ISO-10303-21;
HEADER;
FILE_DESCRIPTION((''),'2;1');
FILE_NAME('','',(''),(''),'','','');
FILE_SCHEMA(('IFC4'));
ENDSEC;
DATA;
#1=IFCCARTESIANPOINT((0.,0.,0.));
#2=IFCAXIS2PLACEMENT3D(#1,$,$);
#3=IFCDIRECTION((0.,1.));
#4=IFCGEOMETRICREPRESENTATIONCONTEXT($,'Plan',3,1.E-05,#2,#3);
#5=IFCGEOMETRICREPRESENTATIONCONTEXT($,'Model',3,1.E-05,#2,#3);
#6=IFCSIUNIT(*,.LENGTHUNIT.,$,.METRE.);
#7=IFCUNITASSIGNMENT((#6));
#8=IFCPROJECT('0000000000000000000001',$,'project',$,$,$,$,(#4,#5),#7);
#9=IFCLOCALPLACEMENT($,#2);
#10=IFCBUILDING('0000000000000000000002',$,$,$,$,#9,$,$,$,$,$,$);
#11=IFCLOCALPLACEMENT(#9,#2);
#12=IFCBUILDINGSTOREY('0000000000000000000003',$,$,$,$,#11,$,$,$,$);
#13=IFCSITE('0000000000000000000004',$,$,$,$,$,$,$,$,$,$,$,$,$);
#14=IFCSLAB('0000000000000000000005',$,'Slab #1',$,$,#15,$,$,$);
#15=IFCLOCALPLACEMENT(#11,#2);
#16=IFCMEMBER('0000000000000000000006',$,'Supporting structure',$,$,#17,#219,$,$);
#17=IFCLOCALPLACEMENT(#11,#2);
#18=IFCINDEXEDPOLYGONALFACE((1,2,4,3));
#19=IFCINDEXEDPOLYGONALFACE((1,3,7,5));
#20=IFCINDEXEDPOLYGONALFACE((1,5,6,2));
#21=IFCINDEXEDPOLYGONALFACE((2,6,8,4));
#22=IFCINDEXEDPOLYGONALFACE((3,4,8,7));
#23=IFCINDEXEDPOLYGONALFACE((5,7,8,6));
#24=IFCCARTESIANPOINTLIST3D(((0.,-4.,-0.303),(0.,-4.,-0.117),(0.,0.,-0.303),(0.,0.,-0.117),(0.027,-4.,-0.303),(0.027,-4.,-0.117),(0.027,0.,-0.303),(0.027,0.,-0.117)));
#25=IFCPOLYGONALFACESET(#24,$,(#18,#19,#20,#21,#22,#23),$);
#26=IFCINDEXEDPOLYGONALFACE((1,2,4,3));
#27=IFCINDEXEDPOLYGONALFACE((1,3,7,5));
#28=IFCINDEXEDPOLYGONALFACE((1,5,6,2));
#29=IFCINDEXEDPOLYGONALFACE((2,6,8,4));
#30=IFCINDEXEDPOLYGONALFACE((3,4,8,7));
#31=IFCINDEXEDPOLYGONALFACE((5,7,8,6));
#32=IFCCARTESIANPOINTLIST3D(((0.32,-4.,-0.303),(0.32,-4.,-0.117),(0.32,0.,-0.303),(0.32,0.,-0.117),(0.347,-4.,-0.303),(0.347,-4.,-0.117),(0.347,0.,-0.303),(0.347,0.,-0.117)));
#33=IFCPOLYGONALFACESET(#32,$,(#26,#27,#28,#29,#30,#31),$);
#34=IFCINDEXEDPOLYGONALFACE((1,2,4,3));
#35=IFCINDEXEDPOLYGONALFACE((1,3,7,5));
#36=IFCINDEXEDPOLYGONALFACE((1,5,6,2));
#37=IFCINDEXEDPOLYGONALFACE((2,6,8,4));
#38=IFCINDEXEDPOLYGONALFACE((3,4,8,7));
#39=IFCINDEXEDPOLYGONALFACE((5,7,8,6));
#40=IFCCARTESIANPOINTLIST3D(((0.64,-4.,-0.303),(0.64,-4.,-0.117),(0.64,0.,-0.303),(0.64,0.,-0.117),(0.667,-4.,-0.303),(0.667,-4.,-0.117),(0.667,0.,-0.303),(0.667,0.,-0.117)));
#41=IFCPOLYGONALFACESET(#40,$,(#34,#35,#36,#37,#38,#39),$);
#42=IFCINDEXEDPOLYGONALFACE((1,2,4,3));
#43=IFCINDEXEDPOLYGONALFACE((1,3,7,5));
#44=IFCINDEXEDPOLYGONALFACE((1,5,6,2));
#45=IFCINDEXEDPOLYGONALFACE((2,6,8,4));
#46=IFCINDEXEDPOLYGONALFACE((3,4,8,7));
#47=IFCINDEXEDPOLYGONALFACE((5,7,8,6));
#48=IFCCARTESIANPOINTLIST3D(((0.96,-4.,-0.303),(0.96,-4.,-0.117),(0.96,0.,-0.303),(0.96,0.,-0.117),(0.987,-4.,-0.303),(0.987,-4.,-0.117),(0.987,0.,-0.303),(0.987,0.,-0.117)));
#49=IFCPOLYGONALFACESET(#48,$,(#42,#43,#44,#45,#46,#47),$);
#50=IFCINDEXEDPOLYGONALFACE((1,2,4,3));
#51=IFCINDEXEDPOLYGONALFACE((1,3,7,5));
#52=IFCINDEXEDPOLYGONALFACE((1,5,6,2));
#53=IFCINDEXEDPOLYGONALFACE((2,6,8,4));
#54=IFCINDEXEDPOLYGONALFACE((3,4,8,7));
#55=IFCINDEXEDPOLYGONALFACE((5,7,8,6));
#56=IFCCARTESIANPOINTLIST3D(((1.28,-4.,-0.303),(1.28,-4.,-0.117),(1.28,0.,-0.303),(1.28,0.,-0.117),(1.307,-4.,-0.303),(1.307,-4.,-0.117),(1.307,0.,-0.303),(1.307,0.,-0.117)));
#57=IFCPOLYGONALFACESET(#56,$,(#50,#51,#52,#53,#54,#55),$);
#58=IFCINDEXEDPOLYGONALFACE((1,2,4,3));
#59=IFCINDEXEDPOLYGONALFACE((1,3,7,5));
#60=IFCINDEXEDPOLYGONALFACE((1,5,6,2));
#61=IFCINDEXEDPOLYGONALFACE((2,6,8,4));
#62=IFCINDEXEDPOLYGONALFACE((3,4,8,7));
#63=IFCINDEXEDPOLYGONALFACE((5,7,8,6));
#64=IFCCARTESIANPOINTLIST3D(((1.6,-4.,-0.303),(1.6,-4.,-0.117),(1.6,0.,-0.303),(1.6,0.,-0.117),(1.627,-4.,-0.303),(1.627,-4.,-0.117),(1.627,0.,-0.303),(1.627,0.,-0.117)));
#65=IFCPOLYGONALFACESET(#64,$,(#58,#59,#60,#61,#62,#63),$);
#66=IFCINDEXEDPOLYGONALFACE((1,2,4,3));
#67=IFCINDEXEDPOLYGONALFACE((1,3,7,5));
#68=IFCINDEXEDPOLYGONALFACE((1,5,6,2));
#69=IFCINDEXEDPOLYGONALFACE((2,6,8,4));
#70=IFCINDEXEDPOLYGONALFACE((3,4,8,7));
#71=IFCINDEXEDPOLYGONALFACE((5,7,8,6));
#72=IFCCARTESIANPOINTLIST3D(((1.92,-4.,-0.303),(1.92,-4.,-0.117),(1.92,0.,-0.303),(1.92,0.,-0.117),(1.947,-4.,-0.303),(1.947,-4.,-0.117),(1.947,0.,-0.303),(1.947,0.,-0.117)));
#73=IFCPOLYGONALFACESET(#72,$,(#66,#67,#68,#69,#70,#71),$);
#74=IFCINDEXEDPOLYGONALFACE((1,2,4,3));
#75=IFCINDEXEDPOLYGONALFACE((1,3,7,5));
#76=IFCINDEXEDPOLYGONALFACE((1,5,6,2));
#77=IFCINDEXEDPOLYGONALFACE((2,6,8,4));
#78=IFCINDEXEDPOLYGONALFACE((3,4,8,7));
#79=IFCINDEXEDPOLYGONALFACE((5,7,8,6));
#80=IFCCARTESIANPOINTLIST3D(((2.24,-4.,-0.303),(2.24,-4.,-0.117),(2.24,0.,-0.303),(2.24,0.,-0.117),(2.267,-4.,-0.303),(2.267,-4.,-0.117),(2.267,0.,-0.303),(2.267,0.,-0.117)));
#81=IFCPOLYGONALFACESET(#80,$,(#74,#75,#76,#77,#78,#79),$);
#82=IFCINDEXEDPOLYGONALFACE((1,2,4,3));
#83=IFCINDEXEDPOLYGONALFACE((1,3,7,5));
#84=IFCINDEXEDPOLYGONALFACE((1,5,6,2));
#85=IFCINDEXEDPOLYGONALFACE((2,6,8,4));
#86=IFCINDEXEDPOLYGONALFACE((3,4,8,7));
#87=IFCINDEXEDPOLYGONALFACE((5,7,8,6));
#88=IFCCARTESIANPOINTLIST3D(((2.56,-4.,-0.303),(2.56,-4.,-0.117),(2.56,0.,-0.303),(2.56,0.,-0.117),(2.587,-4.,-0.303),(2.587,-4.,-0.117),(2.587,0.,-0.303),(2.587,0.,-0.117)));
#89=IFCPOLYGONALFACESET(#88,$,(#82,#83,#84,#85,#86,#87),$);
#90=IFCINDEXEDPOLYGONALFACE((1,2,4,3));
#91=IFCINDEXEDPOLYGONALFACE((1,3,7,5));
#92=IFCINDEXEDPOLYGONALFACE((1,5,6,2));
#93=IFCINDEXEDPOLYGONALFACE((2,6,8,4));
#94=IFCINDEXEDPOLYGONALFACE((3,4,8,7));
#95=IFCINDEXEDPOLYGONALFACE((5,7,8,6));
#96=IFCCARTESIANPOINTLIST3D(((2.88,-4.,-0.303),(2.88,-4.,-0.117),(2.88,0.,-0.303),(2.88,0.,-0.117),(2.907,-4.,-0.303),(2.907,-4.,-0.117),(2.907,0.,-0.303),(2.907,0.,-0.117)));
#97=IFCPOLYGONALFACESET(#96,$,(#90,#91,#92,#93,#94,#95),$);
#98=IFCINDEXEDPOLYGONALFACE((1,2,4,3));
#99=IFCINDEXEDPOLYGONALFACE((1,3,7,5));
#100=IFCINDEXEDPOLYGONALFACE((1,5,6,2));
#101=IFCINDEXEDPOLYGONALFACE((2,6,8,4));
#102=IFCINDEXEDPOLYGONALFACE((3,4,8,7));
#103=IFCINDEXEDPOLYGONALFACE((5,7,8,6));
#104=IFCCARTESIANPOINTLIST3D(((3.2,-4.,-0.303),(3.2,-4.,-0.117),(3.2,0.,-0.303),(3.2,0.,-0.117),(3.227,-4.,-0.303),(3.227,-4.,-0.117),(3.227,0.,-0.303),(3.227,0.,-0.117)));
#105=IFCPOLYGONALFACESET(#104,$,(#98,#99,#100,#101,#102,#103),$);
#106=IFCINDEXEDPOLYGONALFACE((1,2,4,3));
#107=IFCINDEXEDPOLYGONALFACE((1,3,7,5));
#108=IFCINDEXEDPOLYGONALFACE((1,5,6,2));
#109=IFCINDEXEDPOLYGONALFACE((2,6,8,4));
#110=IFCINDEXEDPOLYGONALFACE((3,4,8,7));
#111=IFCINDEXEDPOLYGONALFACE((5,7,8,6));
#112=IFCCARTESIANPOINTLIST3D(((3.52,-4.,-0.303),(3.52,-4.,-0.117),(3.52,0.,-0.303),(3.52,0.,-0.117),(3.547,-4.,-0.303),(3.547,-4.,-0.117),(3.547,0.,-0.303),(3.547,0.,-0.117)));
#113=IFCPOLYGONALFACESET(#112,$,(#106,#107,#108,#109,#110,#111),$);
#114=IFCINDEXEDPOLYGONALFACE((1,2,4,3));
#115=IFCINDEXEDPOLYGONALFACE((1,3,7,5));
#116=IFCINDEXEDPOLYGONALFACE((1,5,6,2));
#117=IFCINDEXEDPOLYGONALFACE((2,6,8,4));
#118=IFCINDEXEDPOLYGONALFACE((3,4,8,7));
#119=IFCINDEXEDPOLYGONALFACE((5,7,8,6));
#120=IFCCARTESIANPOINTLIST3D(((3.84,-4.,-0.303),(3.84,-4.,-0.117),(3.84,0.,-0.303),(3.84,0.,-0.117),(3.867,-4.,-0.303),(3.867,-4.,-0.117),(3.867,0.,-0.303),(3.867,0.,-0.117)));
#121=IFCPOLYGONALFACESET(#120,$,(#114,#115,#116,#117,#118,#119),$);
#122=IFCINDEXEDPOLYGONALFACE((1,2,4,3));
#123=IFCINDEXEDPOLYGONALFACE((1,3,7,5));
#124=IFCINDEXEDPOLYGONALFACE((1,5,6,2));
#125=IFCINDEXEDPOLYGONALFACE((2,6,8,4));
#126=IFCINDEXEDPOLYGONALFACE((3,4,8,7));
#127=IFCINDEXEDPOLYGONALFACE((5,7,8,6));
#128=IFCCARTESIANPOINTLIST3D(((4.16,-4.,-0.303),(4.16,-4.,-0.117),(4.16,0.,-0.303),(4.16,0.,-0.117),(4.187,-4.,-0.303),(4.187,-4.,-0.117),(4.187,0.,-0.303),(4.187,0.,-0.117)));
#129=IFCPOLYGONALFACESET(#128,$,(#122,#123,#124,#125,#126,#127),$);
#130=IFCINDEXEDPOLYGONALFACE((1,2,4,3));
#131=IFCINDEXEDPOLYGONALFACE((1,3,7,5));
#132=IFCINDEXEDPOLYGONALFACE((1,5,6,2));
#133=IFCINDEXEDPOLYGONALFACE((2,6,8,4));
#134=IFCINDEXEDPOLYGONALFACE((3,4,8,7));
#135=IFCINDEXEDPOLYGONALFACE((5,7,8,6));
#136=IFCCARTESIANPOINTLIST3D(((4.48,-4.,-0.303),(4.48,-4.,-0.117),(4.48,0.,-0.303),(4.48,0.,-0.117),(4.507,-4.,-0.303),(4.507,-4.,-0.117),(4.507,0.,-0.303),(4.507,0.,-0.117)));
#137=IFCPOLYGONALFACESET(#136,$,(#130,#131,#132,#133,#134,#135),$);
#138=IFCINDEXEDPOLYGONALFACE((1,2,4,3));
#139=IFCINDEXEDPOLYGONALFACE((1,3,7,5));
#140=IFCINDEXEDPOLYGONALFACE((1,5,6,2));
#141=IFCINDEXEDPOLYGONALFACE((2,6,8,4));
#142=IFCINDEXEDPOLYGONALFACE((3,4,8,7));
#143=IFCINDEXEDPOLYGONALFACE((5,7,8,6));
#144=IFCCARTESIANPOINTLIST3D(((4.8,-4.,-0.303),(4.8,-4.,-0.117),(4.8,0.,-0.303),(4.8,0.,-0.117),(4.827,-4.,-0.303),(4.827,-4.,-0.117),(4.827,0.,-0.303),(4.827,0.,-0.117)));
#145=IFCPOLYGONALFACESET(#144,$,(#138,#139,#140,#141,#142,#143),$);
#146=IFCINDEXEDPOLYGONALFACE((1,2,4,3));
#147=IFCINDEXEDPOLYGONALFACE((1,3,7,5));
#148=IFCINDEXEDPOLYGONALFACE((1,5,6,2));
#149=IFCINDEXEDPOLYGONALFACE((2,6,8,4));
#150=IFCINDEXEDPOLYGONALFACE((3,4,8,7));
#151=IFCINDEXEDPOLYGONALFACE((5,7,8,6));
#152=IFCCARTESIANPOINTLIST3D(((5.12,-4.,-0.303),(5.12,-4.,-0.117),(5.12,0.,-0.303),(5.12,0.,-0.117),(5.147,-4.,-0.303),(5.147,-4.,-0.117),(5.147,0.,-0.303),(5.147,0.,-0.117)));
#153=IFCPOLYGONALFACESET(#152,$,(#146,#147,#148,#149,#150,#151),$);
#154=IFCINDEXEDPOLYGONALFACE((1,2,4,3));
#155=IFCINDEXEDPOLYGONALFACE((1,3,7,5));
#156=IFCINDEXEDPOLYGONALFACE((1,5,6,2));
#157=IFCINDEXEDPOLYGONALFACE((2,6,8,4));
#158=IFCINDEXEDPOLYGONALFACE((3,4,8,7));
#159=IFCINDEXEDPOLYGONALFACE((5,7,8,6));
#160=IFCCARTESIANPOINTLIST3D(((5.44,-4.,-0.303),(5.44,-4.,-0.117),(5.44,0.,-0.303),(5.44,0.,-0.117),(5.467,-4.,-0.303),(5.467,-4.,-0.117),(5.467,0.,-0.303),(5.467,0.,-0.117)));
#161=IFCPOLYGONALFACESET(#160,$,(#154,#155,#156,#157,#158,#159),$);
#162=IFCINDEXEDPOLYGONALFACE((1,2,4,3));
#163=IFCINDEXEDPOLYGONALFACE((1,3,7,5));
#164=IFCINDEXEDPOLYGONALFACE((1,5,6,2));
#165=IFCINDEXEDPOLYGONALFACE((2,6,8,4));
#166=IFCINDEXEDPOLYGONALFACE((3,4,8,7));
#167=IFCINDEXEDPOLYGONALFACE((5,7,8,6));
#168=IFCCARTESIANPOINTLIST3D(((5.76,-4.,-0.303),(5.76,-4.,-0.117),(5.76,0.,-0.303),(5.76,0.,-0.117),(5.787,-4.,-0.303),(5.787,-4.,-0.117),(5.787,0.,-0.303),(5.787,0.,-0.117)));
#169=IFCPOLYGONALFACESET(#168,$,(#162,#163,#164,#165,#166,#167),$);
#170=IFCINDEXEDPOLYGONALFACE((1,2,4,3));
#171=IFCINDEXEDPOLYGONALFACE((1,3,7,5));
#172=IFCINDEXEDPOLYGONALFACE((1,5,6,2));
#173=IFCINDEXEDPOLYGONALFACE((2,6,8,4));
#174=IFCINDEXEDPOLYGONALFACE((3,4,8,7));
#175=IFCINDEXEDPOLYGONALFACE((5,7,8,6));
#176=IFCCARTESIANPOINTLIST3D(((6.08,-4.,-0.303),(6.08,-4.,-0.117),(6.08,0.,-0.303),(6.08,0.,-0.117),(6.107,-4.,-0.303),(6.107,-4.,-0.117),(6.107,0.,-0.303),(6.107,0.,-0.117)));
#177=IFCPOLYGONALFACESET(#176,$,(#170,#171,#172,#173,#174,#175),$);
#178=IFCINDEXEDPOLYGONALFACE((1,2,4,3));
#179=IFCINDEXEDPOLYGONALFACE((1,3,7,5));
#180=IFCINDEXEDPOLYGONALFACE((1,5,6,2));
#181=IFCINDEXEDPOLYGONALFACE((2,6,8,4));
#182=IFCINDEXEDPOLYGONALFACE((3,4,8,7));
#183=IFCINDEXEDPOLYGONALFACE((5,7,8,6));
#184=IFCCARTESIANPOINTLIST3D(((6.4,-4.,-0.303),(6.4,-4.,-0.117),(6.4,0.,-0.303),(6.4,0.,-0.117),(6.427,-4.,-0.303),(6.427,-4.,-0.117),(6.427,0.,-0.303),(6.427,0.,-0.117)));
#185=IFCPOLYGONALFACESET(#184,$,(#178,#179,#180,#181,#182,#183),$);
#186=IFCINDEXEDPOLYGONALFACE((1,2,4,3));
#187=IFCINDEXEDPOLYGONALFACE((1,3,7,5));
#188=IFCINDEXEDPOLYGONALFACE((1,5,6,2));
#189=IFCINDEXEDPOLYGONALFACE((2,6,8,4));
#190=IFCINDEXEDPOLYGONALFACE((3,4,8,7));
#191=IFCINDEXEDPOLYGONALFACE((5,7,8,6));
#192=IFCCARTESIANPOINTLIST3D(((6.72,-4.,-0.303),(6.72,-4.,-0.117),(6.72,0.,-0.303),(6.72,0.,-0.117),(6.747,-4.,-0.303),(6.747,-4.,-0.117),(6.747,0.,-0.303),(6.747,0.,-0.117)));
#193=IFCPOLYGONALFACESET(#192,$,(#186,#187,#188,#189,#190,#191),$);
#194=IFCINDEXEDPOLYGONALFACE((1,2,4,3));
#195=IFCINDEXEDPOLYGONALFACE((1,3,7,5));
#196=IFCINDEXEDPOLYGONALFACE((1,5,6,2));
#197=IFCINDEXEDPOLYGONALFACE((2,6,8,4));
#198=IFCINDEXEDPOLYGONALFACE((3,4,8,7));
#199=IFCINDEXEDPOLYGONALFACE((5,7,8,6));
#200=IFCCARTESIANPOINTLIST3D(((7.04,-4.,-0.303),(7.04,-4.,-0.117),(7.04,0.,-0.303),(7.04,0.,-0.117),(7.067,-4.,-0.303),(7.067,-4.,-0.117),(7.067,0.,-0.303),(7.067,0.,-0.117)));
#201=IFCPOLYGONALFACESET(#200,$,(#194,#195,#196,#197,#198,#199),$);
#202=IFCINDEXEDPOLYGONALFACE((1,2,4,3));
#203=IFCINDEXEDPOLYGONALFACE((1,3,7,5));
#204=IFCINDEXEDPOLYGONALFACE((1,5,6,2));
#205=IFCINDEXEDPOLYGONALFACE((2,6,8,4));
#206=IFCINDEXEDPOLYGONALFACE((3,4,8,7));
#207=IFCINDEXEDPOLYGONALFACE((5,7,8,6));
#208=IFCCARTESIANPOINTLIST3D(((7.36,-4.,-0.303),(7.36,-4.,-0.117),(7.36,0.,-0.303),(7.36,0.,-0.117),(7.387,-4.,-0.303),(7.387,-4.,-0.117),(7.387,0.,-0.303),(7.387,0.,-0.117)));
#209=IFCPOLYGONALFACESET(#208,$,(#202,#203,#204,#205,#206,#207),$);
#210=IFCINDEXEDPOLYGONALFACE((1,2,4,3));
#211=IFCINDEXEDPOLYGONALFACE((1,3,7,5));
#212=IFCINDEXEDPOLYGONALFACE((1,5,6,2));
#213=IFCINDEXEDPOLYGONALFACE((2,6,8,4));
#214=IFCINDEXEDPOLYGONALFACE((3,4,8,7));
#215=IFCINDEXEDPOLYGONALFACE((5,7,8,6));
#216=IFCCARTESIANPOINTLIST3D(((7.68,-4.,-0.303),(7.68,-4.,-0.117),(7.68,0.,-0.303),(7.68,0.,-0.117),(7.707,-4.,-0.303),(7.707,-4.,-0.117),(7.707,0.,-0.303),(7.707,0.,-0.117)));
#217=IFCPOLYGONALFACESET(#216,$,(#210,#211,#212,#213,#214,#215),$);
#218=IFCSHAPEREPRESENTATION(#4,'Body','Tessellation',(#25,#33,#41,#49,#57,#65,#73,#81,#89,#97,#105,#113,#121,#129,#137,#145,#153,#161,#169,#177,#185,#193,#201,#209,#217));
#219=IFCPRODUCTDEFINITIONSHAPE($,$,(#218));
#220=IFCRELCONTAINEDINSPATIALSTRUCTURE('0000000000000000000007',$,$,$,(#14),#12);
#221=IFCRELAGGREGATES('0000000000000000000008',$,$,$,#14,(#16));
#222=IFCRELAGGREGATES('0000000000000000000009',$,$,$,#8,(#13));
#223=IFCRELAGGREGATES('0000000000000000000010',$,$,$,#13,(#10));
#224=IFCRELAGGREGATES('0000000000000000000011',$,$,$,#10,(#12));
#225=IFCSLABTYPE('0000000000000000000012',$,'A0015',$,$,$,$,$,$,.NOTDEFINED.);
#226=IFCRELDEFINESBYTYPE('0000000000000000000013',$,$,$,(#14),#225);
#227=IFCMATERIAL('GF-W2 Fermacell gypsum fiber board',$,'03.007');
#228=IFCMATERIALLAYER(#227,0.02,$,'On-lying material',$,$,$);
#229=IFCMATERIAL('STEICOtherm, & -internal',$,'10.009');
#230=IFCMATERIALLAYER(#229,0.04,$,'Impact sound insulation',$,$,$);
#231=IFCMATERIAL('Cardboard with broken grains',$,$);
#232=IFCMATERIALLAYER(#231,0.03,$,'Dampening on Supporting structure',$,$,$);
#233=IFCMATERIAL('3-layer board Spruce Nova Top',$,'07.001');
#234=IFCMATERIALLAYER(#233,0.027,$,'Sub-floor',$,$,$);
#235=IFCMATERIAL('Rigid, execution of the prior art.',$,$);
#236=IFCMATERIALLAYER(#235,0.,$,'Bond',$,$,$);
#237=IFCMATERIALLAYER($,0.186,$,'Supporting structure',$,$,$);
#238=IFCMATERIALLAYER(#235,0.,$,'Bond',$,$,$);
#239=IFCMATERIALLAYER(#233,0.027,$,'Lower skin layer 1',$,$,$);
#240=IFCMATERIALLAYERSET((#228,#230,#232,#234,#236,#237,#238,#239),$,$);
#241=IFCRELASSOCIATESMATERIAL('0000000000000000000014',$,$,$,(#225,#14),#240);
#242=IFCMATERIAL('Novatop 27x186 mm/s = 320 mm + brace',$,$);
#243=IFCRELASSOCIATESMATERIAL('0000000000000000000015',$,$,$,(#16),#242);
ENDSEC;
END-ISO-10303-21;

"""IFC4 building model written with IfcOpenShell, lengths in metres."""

from ifc_helpers import new_model, si_unit, direction, frame, frame_2d, origin, place, context, project, spatial, rectangle, extrude, material, layer, layer_set, type_object, element, aggregate, save


model = new_model("IFC4")

# Units and contexts
plan_context = context("Plan", 3, precision=1e-05, world=origin(), true_north=direction((0.0, 1.0)))
model_context = context("Model", 3, precision=1e-05, world=origin(), true_north=direction((0.0, 1.0)))
ifc_project = project(units=[si_unit("LENGTHUNIT", "METRE")], contexts=[plan_context, model_context])

# Site, building, storey
site = spatial("IfcSite", under=ifc_project)
building_placement = place(None, origin())
building = spatial("IfcBuilding", under=site, at=building_placement)
storey_placement = place(building_placement, origin())
storey = spatial("IfcBuildingStorey", under=building, at=storey_placement)

# Slab, member
ifc_material_1 = material(Name="GF-W2 Fermacell gypsum fiber board", Category="03.007")
ifc_layer_1 = layer(ifc_material_1, 0.02, Name="On-lying material")
ifc_material_2 = material(Name="STEICOtherm, & -internal", Category="10.009")
ifc_layer_2 = layer(ifc_material_2, 0.04, Name="Impact sound insulation")
ifc_material_3 = material(Name="Cardboard with broken grains")
ifc_layer_3 = layer(ifc_material_3, 0.03, Name="Dampening on Supporting structure")
ifc_material_4 = material(Name="3-layer board Spruce Nova Top", Category="07.001")
ifc_layer_4 = layer(ifc_material_4, 0.027, Name="Sub-floor")
ifc_material_5 = material(Name="Rigid, execution of the prior art.")
ifc_layer_5 = layer(ifc_material_5, 0.0, Name="Bond")
ifc_layer_6 = layer(None, 0.186, Name="Supporting structure")
ifc_layer_7 = layer(ifc_material_5, 0.0, Name="Bond")
ifc_layer_8 = layer(ifc_material_4, 0.027, Name="Lower skin layer 1")
ifc_layer_set = layer_set([ifc_layer_1, ifc_layer_2, ifc_layer_3, ifc_layer_4, ifc_layer_5, ifc_layer_6, ifc_layer_7, ifc_layer_8])
slab_type = type_object("IfcSlabType", Name="A0015", PredefinedType="NOTDEFINED", material=ifc_layer_set)
slab_placement = place(None, frame((0.0, 0.0, 0.0), z_axis=(0.0, 0.0, -1.0), x_axis=(1.0, 0.0, 0.0)))
slab = element("IfcSlab", 1, at=slab_placement, inside=storey, type_object=slab_type, material=ifc_layer_set, Name="Slab #1")
ifc_material_6 = material(Name="Novatop 27x186 mm/s = 320 mm + brace")
member_1_placement = place(slab_placement, origin())
member_1 = element("IfcMember", 2, at=member_1_placement, material=ifc_material_6, Name="Supporting structure", context=plan_context, shape_type="SweptSolid", body=[
    extrude(rectangle(XDim=0.027, YDim=0.186, at=frame_2d((0.0135, 0.093), x_axis=(1.0, 0.0))), frame((0.0, 4.0, 0.117), z_axis=(0.0, -1.0, 0.0), x_axis=(1.0, 0.0, 0.0)), (0.0, 0.0, 1.0), 4.0),
    extrude(rectangle(XDim=0.027, YDim=0.186, at=frame_2d((0.0135, 0.093), x_axis=(1.0, 0.0))), frame((0.32, 4.0, 0.117), z_axis=(0.0, -1.0, 0.0), x_axis=(1.0, 0.0, 0.0)), (0.0, 0.0, 1.0), 4.0),
    extrude(rectangle(XDim=0.027, YDim=0.186, at=frame_2d((0.0135, 0.093), x_axis=(1.0, 0.0))), frame((0.64, 4.0, 0.117), z_axis=(0.0, -1.0, 0.0), x_axis=(1.0, 0.0, 0.0)), (0.0, 0.0, 1.0), 4.0),
    extrude(rectangle(XDim=0.027, YDim=0.186, at=frame_2d((0.0135, 0.093), x_axis=(1.0, 0.0))), frame((0.96, 4.0, 0.117), z_axis=(0.0, -1.0, 0.0), x_axis=(1.0, 0.0, 0.0)), (0.0, 0.0, 1.0), 4.0),
    extrude(rectangle(XDim=0.027, YDim=0.186, at=frame_2d((0.0135, 0.093), x_axis=(1.0, 0.0))), frame((1.28, 4.0, 0.117), z_axis=(0.0, -1.0, 0.0), x_axis=(1.0, 0.0, 0.0)), (0.0, 0.0, 1.0), 4.0),
    extrude(rectangle(XDim=0.027, YDim=0.186, at=frame_2d((0.0135, 0.093), x_axis=(1.0, 0.0))), frame((1.6, 4.0, 0.117), z_axis=(0.0, -1.0, 0.0), x_axis=(1.0, 0.0, 0.0)), (0.0, 0.0, 1.0), 4.0),
    extrude(rectangle(XDim=0.027, YDim=0.186, at=frame_2d((0.0135, 0.093), x_axis=(1.0, 0.0))), frame((1.92, 4.0, 0.117), z_axis=(0.0, -1.0, 0.0), x_axis=(1.0, 0.0, 0.0)), (0.0, 0.0, 1.0), 4.0),
    extrude(rectangle(XDim=0.027, YDim=0.186, at=frame_2d((0.0135, 0.093), x_axis=(1.0, 0.0))), frame((2.24, 4.0, 0.117), z_axis=(0.0, -1.0, 0.0), x_axis=(1.0, 0.0, 0.0)), (0.0, 0.0, 1.0), 4.0),
    extrude(rectangle(XDim=0.027, YDim=0.186, at=frame_2d((0.0135, 0.093), x_axis=(1.0, 0.0))), frame((2.56, 4.0, 0.117), z_axis=(0.0, -1.0, 0.0), x_axis=(1.0, 0.0, 0.0)), (0.0, 0.0, 1.0), 4.0),
    extrude(rectangle(XDim=0.027, YDim=0.186, at=frame_2d((0.0135, 0.093), x_axis=(1.0, 0.0))), frame((2.88, 4.0, 0.117), z_axis=(0.0, -1.0, 0.0), x_axis=(1.0, 0.0, 0.0)), (0.0, 0.0, 1.0), 4.0),
    extrude(rectangle(XDim=0.027, YDim=0.186, at=frame_2d((0.0135, 0.093), x_axis=(1.0, 0.0))), frame((3.2, 4.0, 0.117), z_axis=(0.0, -1.0, 0.0), x_axis=(1.0, 0.0, 0.0)), (0.0, 0.0, 1.0), 4.0),
    extrude(rectangle(XDim=0.027, YDim=0.186, at=frame_2d((0.0135, 0.093), x_axis=(1.0, 0.0))), frame((3.52, 4.0, 0.117), z_axis=(0.0, -1.0, 0.0), x_axis=(1.0, 0.0, 0.0)), (0.0, 0.0, 1.0), 4.0),
    extrude(rectangle(XDim=0.027, YDim=0.186, at=frame_2d((0.0135, 0.093), x_axis=(1.0, 0.0))), frame((3.84, 4.0, 0.117), z_axis=(0.0, -1.0, 0.0), x_axis=(1.0, 0.0, 0.0)), (0.0, 0.0, 1.0), 4.0),
    extrude(rectangle(XDim=0.027, YDim=0.186, at=frame_2d((0.0135, 0.093), x_axis=(1.0, 0.0))), frame((4.16, 4.0, 0.117), z_axis=(0.0, -1.0, 0.0), x_axis=(1.0, 0.0, 0.0)), (0.0, 0.0, 1.0), 4.0),
    extrude(rectangle(XDim=0.027, YDim=0.186, at=frame_2d((0.0135, 0.093), x_axis=(1.0, 0.0))), frame((4.48, 4.0, 0.117), z_axis=(0.0, -1.0, 0.0), x_axis=(1.0, 0.0, 0.0)), (0.0, 0.0, 1.0), 4.0),
    extrude(rectangle(XDim=0.027, YDim=0.186, at=frame_2d((0.0135, 0.093), x_axis=(1.0, 0.0))), frame((4.8, 4.0, 0.117), z_axis=(0.0, -1.0, 0.0), x_axis=(1.0, 0.0, 0.0)), (0.0, 0.0, 1.0), 4.0),
    extrude(rectangle(XDim=0.027, YDim=0.186, at=frame_2d((0.0135, 0.093), x_axis=(1.0, 0.0))), frame((5.12, 4.0, 0.117), z_axis=(0.0, -1.0, 0.0), x_axis=(1.0, 0.0, 0.0)), (0.0, 0.0, 1.0), 4.0),
    extrude(rectangle(XDim=0.027, YDim=0.186, at=frame_2d((0.0135, 0.093), x_axis=(1.0, 0.0))), frame((5.44, 4.0, 0.117), z_axis=(0.0, -1.0, 0.0), x_axis=(1.0, 0.0, 0.0)), (0.0, 0.0, 1.0), 4.0),
    extrude(rectangle(XDim=0.027, YDim=0.186, at=frame_2d((0.0135, 0.093), x_axis=(1.0, 0.0))), frame((5.76, 4.0, 0.117), z_axis=(0.0, -1.0, 0.0), x_axis=(1.0, 0.0, 0.0)), (0.0, 0.0, 1.0), 4.0),
    extrude(rectangle(XDim=0.027, YDim=0.186, at=frame_2d((0.0135, 0.093), x_axis=(1.0, 0.0))), frame((6.08, 4.0, 0.117), z_axis=(0.0, -1.0, 0.0), x_axis=(1.0, 0.0, 0.0)), (0.0, 0.0, 1.0), 4.0),
    extrude(rectangle(XDim=0.027, YDim=0.186, at=frame_2d((0.0135, 0.093), x_axis=(1.0, 0.0))), frame((6.4, 4.0, 0.117), z_axis=(0.0, -1.0, 0.0), x_axis=(1.0, 0.0, 0.0)), (0.0, 0.0, 1.0), 4.0),
    extrude(rectangle(XDim=0.027, YDim=0.186, at=frame_2d((0.0135, 0.093), x_axis=(1.0, 0.0))), frame((6.72, 4.0, 0.117), z_axis=(0.0, -1.0, 0.0), x_axis=(1.0, 0.0, 0.0)), (0.0, 0.0, 1.0), 4.0),
    extrude(rectangle(XDim=0.027, YDim=0.186, at=frame_2d((0.0135, 0.093), x_axis=(1.0, 0.0))), frame((7.04, 4.0, 0.117), z_axis=(0.0, -1.0, 0.0), x_axis=(1.0, 0.0, 0.0)), (0.0, 0.0, 1.0), 4.0),
    extrude(rectangle(XDim=0.027, YDim=0.186, at=frame_2d((0.0135, 0.093), x_axis=(1.0, 0.0))), frame((7.36, 4.0, 0.117), z_axis=(0.0, -1.0, 0.0), x_axis=(1.0, 0.0, 0.0)), (0.0, 0.0, 1.0), 4.0),
    extrude(rectangle(XDim=0.027, YDim=0.186, at=frame_2d((0.0135, 0.093), x_axis=(1.0, 0.0))), frame((7.68, 4.0, 0.117), z_axis=(0.0, -1.0, 0.0), x_axis=(1.0, 0.0, 0.0)), (0.0, 0.0, 1.0), 4.0),
])
aggregate(slab, [member_1])

save(model, "model.ifc")
